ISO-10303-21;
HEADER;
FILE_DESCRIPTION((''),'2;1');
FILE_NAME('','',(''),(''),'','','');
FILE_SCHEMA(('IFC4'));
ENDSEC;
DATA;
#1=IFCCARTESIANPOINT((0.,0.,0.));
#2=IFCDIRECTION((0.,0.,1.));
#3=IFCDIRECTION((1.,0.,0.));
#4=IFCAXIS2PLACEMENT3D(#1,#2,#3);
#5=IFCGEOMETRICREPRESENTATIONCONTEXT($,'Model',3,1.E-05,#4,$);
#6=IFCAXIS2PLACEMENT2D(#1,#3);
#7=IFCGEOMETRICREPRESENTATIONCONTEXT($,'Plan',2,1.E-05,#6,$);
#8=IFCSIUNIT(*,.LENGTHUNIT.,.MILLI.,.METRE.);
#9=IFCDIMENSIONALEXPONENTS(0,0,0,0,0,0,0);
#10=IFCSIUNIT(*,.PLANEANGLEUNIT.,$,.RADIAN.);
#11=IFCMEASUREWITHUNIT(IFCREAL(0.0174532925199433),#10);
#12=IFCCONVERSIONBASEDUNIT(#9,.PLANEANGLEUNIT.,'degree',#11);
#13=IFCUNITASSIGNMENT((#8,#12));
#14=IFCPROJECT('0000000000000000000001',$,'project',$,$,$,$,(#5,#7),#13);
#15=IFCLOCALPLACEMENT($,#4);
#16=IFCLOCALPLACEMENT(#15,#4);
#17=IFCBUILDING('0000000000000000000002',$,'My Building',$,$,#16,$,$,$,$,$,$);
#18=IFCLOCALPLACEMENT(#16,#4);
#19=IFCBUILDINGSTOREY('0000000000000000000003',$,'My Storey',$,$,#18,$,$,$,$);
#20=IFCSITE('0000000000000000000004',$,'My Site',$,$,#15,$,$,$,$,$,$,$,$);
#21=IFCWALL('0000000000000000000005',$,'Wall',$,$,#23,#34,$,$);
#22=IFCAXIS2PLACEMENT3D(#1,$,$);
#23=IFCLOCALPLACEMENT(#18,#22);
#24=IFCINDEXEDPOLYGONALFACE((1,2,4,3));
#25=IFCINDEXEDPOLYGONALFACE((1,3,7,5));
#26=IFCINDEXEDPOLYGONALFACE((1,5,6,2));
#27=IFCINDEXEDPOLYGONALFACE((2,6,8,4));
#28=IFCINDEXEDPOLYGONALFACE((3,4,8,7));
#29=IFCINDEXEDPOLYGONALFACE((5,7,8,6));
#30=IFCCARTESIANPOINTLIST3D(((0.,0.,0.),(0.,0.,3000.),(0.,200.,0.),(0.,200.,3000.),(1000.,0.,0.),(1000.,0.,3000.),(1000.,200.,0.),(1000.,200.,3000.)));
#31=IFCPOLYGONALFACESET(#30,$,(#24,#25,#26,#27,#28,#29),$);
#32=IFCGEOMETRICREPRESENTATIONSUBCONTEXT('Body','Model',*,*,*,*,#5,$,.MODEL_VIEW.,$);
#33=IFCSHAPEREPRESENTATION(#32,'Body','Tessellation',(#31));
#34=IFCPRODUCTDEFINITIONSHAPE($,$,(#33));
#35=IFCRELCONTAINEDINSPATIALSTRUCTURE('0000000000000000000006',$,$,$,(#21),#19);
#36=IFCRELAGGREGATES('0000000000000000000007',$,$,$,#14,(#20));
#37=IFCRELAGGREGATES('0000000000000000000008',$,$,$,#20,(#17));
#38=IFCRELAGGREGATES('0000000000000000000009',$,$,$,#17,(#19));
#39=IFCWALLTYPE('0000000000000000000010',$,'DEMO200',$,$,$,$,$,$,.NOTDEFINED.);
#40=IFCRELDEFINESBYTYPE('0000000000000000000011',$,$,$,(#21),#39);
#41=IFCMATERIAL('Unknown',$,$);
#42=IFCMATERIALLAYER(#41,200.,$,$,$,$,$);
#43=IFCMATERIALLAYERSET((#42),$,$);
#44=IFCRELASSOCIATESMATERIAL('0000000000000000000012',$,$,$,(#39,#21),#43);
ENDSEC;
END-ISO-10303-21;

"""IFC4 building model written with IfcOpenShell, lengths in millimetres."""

from ifc_helpers import new_model, entity, si_unit, converted_unit, frame, frame_2d, origin_with_axes, place, context, subcontext, project, spatial, polyline, outline, extrude, material, layer, layer_set, layer_usage, type_object, element, save


model = new_model("IFC4")

# Units and contexts
model_context = context("Model", 3, precision=1e-05, world=origin_with_axes())
plan_context = context("Plan", 2, precision=1e-05, world=frame_2d((0.0, 0.0, 0.0), x_axis=(1.0, 0.0, 0.0)))
body_context = subcontext(model_context, "Body", "Model", "MODEL_VIEW")
ifc_project = project(units=[si_unit("LENGTHUNIT", "METRE", prefix="MILLI"), converted_unit("PLANEANGLEUNIT", "degree", entity("IfcReal", 0.0174532925199433), si_unit("PLANEANGLEUNIT", "RADIAN"), dimensions=[0, 0, 0, 0, 0, 0, 0])], contexts=[model_context, plan_context])

# Site, building, storey
site_placement = place(None, origin_with_axes())
site = spatial("IfcSite", under=ifc_project, at=site_placement, Name="My Site")
building_placement = place(site_placement, origin_with_axes())
building = spatial("IfcBuilding", under=site, at=building_placement, Name="My Building")
storey_placement = place(building_placement, origin_with_axes())
storey = spatial("IfcBuildingStorey", under=building, at=storey_placement, Name="My Storey")

# Wall
ifc_material = material(Name="Unknown")
ifc_layer = layer(ifc_material, 200.0)
ifc_layer_set = layer_set([ifc_layer])
ifc_layer_usage = layer_usage(ifc_layer_set, "AXIS2", "POSITIVE", 0.0)
wall_type = type_object("IfcWallType", Name="DEMO200", material=ifc_layer_set)
wall_placement = place(storey_placement, origin_with_axes())
element("IfcWall", 1, at=wall_placement, inside=storey, type_object=wall_type, material=ifc_layer_usage, Name="Wall", context=body_context, shape_type="SweptSolid", body=[
    extrude(outline(polyline([(-100.0, -500.0), (100.0, -500.0), (100.0, 500.0), (-100.0, 500.0), (-100.0, -500.0)])), frame((500.0, 100.0, 0.0), z_axis=(0.0, 0.0, -1.0), x_axis=(0.0, -1.0, 0.0)), (0.0, 0.0, -1.0), 3000.0),
])

save(model, "model.ifc")
